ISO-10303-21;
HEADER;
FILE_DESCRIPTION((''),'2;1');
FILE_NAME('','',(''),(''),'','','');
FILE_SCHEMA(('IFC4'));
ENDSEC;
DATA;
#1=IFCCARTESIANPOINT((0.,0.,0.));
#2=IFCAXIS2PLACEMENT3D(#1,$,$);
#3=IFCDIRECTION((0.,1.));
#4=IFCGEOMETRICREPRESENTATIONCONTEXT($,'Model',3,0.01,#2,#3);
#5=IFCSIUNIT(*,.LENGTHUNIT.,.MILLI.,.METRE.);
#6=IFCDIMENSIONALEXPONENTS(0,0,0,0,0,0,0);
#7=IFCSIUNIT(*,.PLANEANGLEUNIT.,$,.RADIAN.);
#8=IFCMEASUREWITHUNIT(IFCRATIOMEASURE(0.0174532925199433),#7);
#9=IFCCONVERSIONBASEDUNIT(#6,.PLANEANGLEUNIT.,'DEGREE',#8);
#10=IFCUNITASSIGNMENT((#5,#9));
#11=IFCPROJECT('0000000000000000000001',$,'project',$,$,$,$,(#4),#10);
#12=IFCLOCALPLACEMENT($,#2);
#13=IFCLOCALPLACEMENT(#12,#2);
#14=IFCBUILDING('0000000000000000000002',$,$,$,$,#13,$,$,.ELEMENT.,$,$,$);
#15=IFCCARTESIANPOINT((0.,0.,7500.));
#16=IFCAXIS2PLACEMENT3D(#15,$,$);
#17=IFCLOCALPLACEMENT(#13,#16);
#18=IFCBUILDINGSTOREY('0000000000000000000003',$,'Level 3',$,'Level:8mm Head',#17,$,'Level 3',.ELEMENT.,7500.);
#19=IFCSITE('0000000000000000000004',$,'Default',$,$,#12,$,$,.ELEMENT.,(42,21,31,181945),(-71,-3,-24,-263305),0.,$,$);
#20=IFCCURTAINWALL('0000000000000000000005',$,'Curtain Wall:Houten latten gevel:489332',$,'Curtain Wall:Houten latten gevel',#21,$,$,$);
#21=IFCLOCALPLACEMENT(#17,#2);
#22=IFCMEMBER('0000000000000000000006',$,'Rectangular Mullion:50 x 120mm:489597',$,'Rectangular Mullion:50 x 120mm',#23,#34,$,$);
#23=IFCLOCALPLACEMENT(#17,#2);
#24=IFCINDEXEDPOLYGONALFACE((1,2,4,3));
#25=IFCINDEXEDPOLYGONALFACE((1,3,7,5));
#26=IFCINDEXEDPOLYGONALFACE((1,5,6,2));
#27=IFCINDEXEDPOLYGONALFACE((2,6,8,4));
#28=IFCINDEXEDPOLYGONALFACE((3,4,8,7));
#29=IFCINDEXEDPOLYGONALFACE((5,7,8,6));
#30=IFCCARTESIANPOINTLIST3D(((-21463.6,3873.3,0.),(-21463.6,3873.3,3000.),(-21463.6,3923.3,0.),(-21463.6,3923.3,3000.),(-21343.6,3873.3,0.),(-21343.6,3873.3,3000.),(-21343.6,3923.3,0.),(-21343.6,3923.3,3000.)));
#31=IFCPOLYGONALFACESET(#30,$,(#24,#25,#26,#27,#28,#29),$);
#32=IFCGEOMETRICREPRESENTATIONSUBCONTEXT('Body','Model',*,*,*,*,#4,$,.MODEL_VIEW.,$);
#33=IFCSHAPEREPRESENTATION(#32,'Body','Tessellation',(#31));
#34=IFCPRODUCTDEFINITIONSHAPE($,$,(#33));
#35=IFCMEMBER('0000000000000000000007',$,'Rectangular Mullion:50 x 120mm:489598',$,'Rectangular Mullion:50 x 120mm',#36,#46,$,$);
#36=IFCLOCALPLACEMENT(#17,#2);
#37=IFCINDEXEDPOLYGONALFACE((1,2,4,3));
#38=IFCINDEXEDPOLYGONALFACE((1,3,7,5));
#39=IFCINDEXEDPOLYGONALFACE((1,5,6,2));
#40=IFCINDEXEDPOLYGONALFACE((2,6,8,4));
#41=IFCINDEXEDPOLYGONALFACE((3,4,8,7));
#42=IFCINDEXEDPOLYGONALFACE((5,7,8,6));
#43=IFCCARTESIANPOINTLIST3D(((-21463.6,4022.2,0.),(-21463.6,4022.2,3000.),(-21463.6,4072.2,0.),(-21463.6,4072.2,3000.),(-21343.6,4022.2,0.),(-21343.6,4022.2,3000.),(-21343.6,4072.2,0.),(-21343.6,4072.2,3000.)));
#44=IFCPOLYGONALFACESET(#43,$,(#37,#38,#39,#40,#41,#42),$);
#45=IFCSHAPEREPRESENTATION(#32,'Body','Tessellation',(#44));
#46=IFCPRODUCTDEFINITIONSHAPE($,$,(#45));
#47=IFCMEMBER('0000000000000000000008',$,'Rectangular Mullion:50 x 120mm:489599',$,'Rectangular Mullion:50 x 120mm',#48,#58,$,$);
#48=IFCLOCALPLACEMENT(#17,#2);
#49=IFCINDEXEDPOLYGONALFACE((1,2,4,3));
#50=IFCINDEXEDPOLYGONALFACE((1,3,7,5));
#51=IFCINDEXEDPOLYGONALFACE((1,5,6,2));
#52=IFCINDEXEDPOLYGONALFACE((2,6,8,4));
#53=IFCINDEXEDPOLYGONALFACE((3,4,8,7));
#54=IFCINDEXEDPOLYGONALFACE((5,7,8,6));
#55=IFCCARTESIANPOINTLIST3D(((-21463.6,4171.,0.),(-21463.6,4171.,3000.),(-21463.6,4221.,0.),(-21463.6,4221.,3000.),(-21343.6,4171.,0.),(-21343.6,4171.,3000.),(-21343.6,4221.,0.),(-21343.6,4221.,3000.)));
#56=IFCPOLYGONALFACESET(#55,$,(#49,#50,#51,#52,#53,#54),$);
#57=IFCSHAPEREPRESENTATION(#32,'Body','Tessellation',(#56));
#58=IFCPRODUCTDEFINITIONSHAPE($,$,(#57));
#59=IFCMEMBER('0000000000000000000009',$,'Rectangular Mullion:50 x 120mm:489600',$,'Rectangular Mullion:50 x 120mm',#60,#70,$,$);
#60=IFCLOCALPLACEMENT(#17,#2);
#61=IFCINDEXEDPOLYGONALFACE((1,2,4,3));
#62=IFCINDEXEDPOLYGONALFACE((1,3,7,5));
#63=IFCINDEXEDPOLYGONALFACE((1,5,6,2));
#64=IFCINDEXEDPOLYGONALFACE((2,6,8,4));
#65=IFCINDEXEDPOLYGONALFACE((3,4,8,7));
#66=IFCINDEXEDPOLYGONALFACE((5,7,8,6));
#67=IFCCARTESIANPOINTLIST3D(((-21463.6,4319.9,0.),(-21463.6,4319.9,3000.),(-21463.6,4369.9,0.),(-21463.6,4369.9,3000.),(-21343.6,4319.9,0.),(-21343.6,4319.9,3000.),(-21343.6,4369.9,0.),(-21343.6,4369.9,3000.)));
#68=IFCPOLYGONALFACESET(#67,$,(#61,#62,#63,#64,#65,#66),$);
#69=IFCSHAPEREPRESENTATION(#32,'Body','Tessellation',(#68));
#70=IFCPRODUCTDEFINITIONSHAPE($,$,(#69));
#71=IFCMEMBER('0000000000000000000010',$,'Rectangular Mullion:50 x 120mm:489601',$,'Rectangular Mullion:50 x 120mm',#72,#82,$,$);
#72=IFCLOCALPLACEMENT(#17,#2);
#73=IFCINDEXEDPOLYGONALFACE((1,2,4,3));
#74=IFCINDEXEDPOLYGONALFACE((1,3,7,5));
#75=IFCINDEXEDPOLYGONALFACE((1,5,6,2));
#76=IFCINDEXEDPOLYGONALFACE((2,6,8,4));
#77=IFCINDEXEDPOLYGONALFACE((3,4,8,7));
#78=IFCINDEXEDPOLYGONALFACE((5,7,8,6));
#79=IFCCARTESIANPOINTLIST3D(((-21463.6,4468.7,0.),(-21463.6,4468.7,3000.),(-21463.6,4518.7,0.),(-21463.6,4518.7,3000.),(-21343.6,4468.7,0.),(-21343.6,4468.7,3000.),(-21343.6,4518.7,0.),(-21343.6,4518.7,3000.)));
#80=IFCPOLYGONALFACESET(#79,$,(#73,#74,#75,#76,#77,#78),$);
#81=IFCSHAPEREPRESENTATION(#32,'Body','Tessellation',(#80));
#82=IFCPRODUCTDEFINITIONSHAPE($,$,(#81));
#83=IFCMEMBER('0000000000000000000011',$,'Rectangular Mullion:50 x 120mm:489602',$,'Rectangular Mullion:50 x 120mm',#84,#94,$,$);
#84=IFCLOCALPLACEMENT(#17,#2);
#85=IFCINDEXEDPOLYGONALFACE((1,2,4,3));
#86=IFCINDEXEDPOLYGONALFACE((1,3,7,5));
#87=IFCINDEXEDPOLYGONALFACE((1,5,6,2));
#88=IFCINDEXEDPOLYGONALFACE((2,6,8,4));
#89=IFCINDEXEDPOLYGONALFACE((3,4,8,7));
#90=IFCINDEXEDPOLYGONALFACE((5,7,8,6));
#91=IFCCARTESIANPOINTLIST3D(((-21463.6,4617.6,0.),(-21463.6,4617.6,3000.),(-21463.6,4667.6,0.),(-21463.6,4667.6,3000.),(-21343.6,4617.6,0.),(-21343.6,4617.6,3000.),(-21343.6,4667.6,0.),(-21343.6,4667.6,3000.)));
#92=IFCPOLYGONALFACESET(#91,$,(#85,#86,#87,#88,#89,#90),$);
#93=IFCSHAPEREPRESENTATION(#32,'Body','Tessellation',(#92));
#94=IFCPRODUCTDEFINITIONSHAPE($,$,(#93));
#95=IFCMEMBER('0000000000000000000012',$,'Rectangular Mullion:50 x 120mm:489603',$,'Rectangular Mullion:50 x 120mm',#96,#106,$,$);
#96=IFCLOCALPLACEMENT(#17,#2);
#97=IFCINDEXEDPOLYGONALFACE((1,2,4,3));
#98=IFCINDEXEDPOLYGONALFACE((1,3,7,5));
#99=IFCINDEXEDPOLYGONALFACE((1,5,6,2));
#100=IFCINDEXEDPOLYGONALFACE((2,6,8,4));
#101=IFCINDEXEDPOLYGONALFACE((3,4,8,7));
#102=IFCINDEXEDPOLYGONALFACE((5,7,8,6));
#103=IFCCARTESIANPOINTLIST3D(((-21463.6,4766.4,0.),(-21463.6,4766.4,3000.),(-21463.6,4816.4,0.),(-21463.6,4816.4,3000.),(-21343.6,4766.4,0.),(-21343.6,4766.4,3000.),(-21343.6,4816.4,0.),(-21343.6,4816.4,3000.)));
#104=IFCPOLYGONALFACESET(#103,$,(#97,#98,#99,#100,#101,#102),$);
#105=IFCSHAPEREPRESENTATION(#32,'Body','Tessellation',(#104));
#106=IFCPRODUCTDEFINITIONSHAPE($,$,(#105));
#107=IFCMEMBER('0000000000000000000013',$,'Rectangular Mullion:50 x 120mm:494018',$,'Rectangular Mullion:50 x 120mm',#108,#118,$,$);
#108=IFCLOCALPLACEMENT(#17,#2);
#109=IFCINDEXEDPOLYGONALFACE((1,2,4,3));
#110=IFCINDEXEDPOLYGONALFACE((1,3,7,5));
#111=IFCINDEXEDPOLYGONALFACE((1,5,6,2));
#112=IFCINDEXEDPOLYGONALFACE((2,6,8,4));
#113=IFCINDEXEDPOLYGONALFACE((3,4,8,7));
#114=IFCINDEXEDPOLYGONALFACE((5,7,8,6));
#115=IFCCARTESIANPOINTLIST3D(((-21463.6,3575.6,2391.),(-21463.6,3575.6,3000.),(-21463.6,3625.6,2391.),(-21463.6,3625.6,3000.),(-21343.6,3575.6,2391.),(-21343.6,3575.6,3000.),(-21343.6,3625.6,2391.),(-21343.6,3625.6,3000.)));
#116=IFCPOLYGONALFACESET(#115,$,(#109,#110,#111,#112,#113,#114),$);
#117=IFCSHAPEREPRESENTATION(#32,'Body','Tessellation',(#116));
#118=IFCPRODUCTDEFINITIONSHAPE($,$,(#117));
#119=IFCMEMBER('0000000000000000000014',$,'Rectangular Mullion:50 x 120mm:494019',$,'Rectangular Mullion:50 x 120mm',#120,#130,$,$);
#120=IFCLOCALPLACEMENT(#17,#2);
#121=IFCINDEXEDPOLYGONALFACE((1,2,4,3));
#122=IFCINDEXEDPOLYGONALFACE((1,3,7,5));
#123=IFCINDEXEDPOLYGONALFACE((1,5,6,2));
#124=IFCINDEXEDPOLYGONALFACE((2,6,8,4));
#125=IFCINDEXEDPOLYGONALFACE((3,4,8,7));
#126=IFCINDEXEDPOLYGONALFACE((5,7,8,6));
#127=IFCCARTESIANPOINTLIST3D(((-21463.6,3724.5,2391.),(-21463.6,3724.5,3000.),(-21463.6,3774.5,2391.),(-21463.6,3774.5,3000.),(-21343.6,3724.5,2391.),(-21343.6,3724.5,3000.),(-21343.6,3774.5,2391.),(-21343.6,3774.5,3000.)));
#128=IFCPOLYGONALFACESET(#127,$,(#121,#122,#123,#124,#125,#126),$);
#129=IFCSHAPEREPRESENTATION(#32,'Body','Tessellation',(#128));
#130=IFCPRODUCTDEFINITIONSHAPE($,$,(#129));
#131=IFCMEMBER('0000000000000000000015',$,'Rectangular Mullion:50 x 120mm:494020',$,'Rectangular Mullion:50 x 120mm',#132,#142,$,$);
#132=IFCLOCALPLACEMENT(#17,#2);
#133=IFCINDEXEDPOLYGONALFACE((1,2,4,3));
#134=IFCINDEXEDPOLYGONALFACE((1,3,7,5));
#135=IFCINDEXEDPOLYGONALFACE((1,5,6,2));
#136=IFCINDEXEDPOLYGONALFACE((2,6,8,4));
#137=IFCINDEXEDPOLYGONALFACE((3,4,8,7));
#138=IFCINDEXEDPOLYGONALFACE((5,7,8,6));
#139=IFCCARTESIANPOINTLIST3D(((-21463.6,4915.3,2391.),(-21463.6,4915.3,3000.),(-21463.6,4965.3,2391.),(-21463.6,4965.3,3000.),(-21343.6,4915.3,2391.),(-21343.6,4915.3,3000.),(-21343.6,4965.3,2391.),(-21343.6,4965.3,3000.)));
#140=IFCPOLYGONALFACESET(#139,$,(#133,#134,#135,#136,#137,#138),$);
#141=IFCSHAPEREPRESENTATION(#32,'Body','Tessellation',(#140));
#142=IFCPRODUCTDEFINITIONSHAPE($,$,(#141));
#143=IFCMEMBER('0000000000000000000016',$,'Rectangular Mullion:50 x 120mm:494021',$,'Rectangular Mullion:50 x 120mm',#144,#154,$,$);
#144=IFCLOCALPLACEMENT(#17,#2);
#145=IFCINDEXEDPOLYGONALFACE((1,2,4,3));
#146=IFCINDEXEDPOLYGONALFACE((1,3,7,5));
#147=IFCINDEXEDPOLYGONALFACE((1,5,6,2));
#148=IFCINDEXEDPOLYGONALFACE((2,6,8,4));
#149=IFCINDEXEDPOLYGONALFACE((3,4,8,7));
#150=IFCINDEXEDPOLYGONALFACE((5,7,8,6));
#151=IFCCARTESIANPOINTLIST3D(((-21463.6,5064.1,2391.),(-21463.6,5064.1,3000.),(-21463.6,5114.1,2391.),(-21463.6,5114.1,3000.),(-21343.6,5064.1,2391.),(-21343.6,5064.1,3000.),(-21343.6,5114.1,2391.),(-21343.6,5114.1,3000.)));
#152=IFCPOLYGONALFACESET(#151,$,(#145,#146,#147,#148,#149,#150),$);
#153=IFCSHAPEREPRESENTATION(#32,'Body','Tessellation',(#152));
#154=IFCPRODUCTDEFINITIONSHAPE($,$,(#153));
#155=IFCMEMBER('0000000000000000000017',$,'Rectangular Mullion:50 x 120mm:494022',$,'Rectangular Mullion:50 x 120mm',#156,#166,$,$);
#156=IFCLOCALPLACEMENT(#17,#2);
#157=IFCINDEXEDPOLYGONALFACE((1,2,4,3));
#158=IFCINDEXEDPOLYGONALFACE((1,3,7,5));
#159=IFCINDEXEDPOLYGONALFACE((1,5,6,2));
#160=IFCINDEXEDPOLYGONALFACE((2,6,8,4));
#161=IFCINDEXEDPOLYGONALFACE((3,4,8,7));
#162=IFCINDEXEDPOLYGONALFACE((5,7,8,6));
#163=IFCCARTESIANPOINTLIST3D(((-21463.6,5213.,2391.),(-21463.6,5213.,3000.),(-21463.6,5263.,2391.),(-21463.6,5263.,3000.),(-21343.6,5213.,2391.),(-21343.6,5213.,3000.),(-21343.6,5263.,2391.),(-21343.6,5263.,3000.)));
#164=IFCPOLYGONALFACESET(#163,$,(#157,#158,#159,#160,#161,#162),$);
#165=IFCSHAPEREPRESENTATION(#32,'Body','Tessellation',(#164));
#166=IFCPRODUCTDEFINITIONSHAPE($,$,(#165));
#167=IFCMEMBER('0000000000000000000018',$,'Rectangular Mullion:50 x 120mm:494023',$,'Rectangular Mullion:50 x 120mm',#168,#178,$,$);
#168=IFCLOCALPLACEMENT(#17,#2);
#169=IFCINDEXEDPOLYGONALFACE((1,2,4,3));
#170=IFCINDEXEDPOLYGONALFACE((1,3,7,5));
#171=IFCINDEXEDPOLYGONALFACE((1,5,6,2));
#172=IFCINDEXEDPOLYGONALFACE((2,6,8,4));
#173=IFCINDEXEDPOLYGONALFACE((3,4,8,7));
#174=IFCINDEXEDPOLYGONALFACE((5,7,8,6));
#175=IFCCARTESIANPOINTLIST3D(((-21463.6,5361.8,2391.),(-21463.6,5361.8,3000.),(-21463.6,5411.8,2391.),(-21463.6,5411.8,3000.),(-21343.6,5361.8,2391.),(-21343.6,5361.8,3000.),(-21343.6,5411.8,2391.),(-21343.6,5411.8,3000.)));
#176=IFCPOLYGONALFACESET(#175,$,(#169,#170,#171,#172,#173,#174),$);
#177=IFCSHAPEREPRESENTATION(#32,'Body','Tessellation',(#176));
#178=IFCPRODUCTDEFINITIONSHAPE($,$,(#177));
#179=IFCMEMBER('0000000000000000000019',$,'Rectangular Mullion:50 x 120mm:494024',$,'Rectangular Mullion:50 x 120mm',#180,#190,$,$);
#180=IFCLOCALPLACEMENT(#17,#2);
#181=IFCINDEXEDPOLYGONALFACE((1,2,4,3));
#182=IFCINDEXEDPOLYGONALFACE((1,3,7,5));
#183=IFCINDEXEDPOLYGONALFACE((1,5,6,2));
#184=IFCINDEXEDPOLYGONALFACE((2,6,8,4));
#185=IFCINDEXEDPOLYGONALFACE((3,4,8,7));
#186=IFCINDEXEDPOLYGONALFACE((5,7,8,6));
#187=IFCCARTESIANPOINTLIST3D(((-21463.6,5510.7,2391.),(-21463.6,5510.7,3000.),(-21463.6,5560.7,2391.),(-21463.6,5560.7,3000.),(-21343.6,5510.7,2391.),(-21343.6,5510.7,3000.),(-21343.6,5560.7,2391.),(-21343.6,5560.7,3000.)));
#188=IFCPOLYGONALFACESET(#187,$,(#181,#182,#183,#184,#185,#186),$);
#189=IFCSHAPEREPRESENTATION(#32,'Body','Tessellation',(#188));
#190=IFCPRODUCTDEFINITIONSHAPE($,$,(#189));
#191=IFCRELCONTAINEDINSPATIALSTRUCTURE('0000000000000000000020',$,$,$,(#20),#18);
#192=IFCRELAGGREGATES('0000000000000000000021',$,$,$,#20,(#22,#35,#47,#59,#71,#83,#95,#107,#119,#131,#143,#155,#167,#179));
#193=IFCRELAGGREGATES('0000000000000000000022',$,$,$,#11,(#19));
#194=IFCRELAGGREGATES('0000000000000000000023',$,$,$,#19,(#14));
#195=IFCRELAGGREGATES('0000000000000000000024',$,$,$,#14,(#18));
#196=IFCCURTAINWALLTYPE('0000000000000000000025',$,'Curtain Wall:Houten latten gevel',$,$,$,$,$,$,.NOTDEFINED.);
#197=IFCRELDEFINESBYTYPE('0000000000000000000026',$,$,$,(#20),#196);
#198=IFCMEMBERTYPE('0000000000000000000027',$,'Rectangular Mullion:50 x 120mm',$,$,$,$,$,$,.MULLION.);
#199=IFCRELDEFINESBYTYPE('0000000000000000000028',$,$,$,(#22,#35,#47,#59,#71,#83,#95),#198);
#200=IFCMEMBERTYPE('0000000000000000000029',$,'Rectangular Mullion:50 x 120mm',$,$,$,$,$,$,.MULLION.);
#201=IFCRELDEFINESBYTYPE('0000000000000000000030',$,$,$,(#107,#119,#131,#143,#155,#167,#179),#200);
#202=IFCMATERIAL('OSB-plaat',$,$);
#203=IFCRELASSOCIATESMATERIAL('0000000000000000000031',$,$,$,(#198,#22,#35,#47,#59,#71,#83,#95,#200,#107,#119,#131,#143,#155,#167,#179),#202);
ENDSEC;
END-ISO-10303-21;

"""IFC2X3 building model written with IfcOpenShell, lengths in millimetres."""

from ifc_helpers import new_model, entity, si_unit, converted_unit, direction, frame, origin, origin_2d_with_axis, place, context, subcontext, project, spatial, rectangle, extrude, source, transform, mapped, material, type_object, type_shapes, element, aggregate, save


model = new_model("IFC2X3")

# Units and contexts
model_context = context("Model", 3, precision=0.01, world=origin(), true_north=direction((0.0, 1.0)))
body_context = subcontext(model_context, "Body", "Model", "MODEL_VIEW")
ifc_project = project(units=[si_unit("LENGTHUNIT", "METRE", prefix="MILLI"), converted_unit("PLANEANGLEUNIT", "DEGREE", entity("IfcRatioMeasure", 0.0174532925199433), si_unit("PLANEANGLEUNIT", "RADIAN"), dimensions=[0, 0, 0, 0, 0, 0, 0])], contexts=[model_context])

# Site, building, storey
site_placement = place(None, frame((0.0, 0.0, 0.0)))
site = spatial("IfcSite", under=ifc_project, at=site_placement, Name="Default", CompositionType="ELEMENT", RefLatitude=(42, 21, 31, 181945), RefLongitude=(-71, -3, -24, -263305), RefElevation=0.0)
building_placement = place(site_placement, origin())
building = spatial("IfcBuilding", under=site, at=building_placement, CompositionType="ELEMENT")
storey_placement = place(building_placement, frame((0.0, 0.0, 7500.0)))
storey = spatial("IfcBuildingStorey", under=building, at=storey_placement, Name="Level 3", ObjectType="Level:8mm Head", LongName="Level 3", CompositionType="ELEMENT", Elevation=7500.0)

# Curtain wall, members
curtain_wall_type = type_object("IfcCurtainWallType", Name="Curtain Wall:Houten latten gevel", PredefinedType="NOTDEFINED")
curtain_wall_placement = place(storey_placement, frame((0.0, 0.0, -7500.0)))
curtain_wall = element("IfcCurtainWall", 1, at=curtain_wall_placement, inside=storey, type_object=curtain_wall_type, Name="Curtain Wall:Houten latten gevel:489332", ObjectType="Curtain Wall:Houten latten gevel")
ifc_material_1 = material(Name="OSB-plaat")
member_type_1 = type_object("IfcMemberType", Name="Rectangular Mullion:50 x 120mm", PredefinedType="MULLION", material=ifc_material_1)
shared_shape_1 = source(origin(), body_context, "Body", "SweptSolid", [
    extrude(rectangle(XDim=120.0, YDim=50.0, at=origin_2d_with_axis()), frame((0.0, 0.0, -3000.0), z_axis=(0.0, 0.0, 1.0), x_axis=(0.0, -1.0, 0.0)), (0.0, 0.0, 1.0), 3000.0),
])
type_shapes(member_type_1, [shared_shape_1])
member_1_placement = place(storey_placement, frame((-21403.6, 3898.3, 0.0), z_axis=(0.0, 0.0, -1.0), x_axis=(0.0, 1.0, 0.0)))
member_1 = element("IfcMember", 2, at=member_1_placement, type_object=member_type_1, material=ifc_material_1, Name="Rectangular Mullion:50 x 120mm:489597", ObjectType="Rectangular Mullion:50 x 120mm", context=body_context, shape_type="MappedRepresentation", body=[
    mapped(shared_shape_1, transform((0.0, 0.0, 0.0), scale=1.0)),
])
member_2_placement = place(storey_placement, frame((-21403.6, 4047.2, 0.0), z_axis=(0.0, 0.0, -1.0), x_axis=(0.0, 1.0, 0.0)))
member_2 = element("IfcMember", 3, at=member_2_placement, type_object=member_type_1, material=ifc_material_1, Name="Rectangular Mullion:50 x 120mm:489598", ObjectType="Rectangular Mullion:50 x 120mm", context=body_context, shape_type="MappedRepresentation", body=[
    mapped(shared_shape_1, transform((0.0, 0.0, 0.0), scale=1.0)),
])
member_3_placement = place(storey_placement, frame((-21403.6, 4196.0, 0.0), z_axis=(0.0, 0.0, -1.0), x_axis=(0.0, 1.0, 0.0)))
member_3 = element("IfcMember", 4, at=member_3_placement, type_object=member_type_1, material=ifc_material_1, Name="Rectangular Mullion:50 x 120mm:489599", ObjectType="Rectangular Mullion:50 x 120mm", context=body_context, shape_type="MappedRepresentation", body=[
    mapped(shared_shape_1, transform((0.0, 0.0, 0.0), scale=1.0)),
])
member_4_placement = place(storey_placement, frame((-21403.6, 4344.9, 0.0), z_axis=(0.0, 0.0, -1.0), x_axis=(0.0, 1.0, 0.0)))
member_4 = element("IfcMember", 5, at=member_4_placement, type_object=member_type_1, material=ifc_material_1, Name="Rectangular Mullion:50 x 120mm:489600", ObjectType="Rectangular Mullion:50 x 120mm", context=body_context, shape_type="MappedRepresentation", body=[
    mapped(shared_shape_1, transform((0.0, 0.0, 0.0), scale=1.0)),
])
member_5_placement = place(storey_placement, frame((-21403.6, 4493.7, 0.0), z_axis=(0.0, 0.0, -1.0), x_axis=(0.0, 1.0, 0.0)))
member_5 = element("IfcMember", 6, at=member_5_placement, type_object=member_type_1, material=ifc_material_1, Name="Rectangular Mullion:50 x 120mm:489601", ObjectType="Rectangular Mullion:50 x 120mm", context=body_context, shape_type="MappedRepresentation", body=[
    mapped(shared_shape_1, transform((0.0, 0.0, 0.0), scale=1.0)),
])
member_6_placement = place(storey_placement, frame((-21403.6, 4642.6, 0.0), z_axis=(0.0, 0.0, -1.0), x_axis=(0.0, 1.0, 0.0)))
member_6 = element("IfcMember", 7, at=member_6_placement, type_object=member_type_1, material=ifc_material_1, Name="Rectangular Mullion:50 x 120mm:489602", ObjectType="Rectangular Mullion:50 x 120mm", context=body_context, shape_type="MappedRepresentation", body=[
    mapped(shared_shape_1, transform((0.0, 0.0, 0.0), scale=1.0)),
])
member_7_placement = place(storey_placement, frame((-21403.6, 4791.4, 0.0), z_axis=(0.0, 0.0, -1.0), x_axis=(0.0, 1.0, 0.0)))
member_7 = element("IfcMember", 8, at=member_7_placement, type_object=member_type_1, material=ifc_material_1, Name="Rectangular Mullion:50 x 120mm:489603", ObjectType="Rectangular Mullion:50 x 120mm", context=body_context, shape_type="MappedRepresentation", body=[
    mapped(shared_shape_1, transform((0.0, 0.0, 0.0), scale=1.0)),
])
member_type_2 = type_object("IfcMemberType", Name="Rectangular Mullion:50 x 120mm", PredefinedType="MULLION", material=ifc_material_1)
shared_shape_2 = source(origin(), body_context, "Body", "SweptSolid", [
    extrude(rectangle(XDim=120.0, YDim=50.0, at=origin_2d_with_axis()), frame((0.0, 0.0, -609.0), z_axis=(0.0, 0.0, 1.0), x_axis=(0.0, -1.0, 0.0)), (0.0, 0.0, 1.0), 609.0),
])
type_shapes(member_type_2, [shared_shape_2])
member_8_placement = place(storey_placement, frame((-21403.6, 3600.6, 2391.0), z_axis=(0.0, 0.0, -1.0), x_axis=(0.0, 1.0, 0.0)))
member_8 = element("IfcMember", 9, at=member_8_placement, type_object=member_type_2, material=ifc_material_1, Name="Rectangular Mullion:50 x 120mm:494018", ObjectType="Rectangular Mullion:50 x 120mm", context=body_context, shape_type="MappedRepresentation", body=[
    mapped(shared_shape_2, transform((0.0, 0.0, 0.0), scale=1.0)),
])
member_9_placement = place(storey_placement, frame((-21403.6, 3749.5, 2391.0), z_axis=(0.0, 0.0, -1.0), x_axis=(0.0, 1.0, 0.0)))
member_9 = element("IfcMember", 10, at=member_9_placement, type_object=member_type_2, material=ifc_material_1, Name="Rectangular Mullion:50 x 120mm:494019", ObjectType="Rectangular Mullion:50 x 120mm", context=body_context, shape_type="MappedRepresentation", body=[
    mapped(shared_shape_2, transform((0.0, 0.0, 0.0), scale=1.0)),
])
member_10_placement = place(storey_placement, frame((-21403.6, 4940.3, 2391.0), z_axis=(0.0, 0.0, -1.0), x_axis=(0.0, 1.0, 0.0)))
member_10 = element("IfcMember", 11, at=member_10_placement, type_object=member_type_2, material=ifc_material_1, Name="Rectangular Mullion:50 x 120mm:494020", ObjectType="Rectangular Mullion:50 x 120mm", context=body_context, shape_type="MappedRepresentation", body=[
    mapped(shared_shape_2, transform((0.0, 0.0, 0.0), scale=1.0)),
])
member_11_placement = place(storey_placement, frame((-21403.6, 5089.1, 2391.0), z_axis=(0.0, 0.0, -1.0), x_axis=(0.0, 1.0, 0.0)))
member_11 = element("IfcMember", 12, at=member_11_placement, type_object=member_type_2, material=ifc_material_1, Name="Rectangular Mullion:50 x 120mm:494021", ObjectType="Rectangular Mullion:50 x 120mm", context=body_context, shape_type="MappedRepresentation", body=[
    mapped(shared_shape_2, transform((0.0, 0.0, 0.0), scale=1.0)),
])
member_12_placement = place(storey_placement, frame((-21403.6, 5238.0, 2391.0), z_axis=(0.0, 0.0, -1.0), x_axis=(0.0, 1.0, 0.0)))
member_12 = element("IfcMember", 13, at=member_12_placement, type_object=member_type_2, material=ifc_material_1, Name="Rectangular Mullion:50 x 120mm:494022", ObjectType="Rectangular Mullion:50 x 120mm", context=body_context, shape_type="MappedRepresentation", body=[
    mapped(shared_shape_2, transform((0.0, 0.0, 0.0), scale=1.0)),
])
member_13_placement = place(storey_placement, frame((-21403.6, 5386.8, 2391.0), z_axis=(0.0, 0.0, -1.0), x_axis=(0.0, 1.0, 0.0)))
member_13 = element("IfcMember", 14, at=member_13_placement, type_object=member_type_2, material=ifc_material_1, Name="Rectangular Mullion:50 x 120mm:494023", ObjectType="Rectangular Mullion:50 x 120mm", context=body_context, shape_type="MappedRepresentation", body=[
    mapped(shared_shape_2, transform((0.0, 0.0, 0.0), scale=1.0)),
])
member_14_placement = place(storey_placement, frame((-21403.6, 5535.7, 2391.0), z_axis=(0.0, 0.0, -1.0), x_axis=(0.0, 1.0, 0.0)))
member_14 = element("IfcMember", 15, at=member_14_placement, type_object=member_type_2, material=ifc_material_1, Name="Rectangular Mullion:50 x 120mm:494024", ObjectType="Rectangular Mullion:50 x 120mm", context=body_context, shape_type="MappedRepresentation", body=[
    mapped(shared_shape_2, transform((0.0, 0.0, 0.0), scale=1.0)),
])
aggregate(curtain_wall, [member_1, member_2, member_3, member_4, member_5, member_6, member_7, member_8, member_9, member_10, member_11, member_12, member_13, member_14])

save(model, "model.ifc")
